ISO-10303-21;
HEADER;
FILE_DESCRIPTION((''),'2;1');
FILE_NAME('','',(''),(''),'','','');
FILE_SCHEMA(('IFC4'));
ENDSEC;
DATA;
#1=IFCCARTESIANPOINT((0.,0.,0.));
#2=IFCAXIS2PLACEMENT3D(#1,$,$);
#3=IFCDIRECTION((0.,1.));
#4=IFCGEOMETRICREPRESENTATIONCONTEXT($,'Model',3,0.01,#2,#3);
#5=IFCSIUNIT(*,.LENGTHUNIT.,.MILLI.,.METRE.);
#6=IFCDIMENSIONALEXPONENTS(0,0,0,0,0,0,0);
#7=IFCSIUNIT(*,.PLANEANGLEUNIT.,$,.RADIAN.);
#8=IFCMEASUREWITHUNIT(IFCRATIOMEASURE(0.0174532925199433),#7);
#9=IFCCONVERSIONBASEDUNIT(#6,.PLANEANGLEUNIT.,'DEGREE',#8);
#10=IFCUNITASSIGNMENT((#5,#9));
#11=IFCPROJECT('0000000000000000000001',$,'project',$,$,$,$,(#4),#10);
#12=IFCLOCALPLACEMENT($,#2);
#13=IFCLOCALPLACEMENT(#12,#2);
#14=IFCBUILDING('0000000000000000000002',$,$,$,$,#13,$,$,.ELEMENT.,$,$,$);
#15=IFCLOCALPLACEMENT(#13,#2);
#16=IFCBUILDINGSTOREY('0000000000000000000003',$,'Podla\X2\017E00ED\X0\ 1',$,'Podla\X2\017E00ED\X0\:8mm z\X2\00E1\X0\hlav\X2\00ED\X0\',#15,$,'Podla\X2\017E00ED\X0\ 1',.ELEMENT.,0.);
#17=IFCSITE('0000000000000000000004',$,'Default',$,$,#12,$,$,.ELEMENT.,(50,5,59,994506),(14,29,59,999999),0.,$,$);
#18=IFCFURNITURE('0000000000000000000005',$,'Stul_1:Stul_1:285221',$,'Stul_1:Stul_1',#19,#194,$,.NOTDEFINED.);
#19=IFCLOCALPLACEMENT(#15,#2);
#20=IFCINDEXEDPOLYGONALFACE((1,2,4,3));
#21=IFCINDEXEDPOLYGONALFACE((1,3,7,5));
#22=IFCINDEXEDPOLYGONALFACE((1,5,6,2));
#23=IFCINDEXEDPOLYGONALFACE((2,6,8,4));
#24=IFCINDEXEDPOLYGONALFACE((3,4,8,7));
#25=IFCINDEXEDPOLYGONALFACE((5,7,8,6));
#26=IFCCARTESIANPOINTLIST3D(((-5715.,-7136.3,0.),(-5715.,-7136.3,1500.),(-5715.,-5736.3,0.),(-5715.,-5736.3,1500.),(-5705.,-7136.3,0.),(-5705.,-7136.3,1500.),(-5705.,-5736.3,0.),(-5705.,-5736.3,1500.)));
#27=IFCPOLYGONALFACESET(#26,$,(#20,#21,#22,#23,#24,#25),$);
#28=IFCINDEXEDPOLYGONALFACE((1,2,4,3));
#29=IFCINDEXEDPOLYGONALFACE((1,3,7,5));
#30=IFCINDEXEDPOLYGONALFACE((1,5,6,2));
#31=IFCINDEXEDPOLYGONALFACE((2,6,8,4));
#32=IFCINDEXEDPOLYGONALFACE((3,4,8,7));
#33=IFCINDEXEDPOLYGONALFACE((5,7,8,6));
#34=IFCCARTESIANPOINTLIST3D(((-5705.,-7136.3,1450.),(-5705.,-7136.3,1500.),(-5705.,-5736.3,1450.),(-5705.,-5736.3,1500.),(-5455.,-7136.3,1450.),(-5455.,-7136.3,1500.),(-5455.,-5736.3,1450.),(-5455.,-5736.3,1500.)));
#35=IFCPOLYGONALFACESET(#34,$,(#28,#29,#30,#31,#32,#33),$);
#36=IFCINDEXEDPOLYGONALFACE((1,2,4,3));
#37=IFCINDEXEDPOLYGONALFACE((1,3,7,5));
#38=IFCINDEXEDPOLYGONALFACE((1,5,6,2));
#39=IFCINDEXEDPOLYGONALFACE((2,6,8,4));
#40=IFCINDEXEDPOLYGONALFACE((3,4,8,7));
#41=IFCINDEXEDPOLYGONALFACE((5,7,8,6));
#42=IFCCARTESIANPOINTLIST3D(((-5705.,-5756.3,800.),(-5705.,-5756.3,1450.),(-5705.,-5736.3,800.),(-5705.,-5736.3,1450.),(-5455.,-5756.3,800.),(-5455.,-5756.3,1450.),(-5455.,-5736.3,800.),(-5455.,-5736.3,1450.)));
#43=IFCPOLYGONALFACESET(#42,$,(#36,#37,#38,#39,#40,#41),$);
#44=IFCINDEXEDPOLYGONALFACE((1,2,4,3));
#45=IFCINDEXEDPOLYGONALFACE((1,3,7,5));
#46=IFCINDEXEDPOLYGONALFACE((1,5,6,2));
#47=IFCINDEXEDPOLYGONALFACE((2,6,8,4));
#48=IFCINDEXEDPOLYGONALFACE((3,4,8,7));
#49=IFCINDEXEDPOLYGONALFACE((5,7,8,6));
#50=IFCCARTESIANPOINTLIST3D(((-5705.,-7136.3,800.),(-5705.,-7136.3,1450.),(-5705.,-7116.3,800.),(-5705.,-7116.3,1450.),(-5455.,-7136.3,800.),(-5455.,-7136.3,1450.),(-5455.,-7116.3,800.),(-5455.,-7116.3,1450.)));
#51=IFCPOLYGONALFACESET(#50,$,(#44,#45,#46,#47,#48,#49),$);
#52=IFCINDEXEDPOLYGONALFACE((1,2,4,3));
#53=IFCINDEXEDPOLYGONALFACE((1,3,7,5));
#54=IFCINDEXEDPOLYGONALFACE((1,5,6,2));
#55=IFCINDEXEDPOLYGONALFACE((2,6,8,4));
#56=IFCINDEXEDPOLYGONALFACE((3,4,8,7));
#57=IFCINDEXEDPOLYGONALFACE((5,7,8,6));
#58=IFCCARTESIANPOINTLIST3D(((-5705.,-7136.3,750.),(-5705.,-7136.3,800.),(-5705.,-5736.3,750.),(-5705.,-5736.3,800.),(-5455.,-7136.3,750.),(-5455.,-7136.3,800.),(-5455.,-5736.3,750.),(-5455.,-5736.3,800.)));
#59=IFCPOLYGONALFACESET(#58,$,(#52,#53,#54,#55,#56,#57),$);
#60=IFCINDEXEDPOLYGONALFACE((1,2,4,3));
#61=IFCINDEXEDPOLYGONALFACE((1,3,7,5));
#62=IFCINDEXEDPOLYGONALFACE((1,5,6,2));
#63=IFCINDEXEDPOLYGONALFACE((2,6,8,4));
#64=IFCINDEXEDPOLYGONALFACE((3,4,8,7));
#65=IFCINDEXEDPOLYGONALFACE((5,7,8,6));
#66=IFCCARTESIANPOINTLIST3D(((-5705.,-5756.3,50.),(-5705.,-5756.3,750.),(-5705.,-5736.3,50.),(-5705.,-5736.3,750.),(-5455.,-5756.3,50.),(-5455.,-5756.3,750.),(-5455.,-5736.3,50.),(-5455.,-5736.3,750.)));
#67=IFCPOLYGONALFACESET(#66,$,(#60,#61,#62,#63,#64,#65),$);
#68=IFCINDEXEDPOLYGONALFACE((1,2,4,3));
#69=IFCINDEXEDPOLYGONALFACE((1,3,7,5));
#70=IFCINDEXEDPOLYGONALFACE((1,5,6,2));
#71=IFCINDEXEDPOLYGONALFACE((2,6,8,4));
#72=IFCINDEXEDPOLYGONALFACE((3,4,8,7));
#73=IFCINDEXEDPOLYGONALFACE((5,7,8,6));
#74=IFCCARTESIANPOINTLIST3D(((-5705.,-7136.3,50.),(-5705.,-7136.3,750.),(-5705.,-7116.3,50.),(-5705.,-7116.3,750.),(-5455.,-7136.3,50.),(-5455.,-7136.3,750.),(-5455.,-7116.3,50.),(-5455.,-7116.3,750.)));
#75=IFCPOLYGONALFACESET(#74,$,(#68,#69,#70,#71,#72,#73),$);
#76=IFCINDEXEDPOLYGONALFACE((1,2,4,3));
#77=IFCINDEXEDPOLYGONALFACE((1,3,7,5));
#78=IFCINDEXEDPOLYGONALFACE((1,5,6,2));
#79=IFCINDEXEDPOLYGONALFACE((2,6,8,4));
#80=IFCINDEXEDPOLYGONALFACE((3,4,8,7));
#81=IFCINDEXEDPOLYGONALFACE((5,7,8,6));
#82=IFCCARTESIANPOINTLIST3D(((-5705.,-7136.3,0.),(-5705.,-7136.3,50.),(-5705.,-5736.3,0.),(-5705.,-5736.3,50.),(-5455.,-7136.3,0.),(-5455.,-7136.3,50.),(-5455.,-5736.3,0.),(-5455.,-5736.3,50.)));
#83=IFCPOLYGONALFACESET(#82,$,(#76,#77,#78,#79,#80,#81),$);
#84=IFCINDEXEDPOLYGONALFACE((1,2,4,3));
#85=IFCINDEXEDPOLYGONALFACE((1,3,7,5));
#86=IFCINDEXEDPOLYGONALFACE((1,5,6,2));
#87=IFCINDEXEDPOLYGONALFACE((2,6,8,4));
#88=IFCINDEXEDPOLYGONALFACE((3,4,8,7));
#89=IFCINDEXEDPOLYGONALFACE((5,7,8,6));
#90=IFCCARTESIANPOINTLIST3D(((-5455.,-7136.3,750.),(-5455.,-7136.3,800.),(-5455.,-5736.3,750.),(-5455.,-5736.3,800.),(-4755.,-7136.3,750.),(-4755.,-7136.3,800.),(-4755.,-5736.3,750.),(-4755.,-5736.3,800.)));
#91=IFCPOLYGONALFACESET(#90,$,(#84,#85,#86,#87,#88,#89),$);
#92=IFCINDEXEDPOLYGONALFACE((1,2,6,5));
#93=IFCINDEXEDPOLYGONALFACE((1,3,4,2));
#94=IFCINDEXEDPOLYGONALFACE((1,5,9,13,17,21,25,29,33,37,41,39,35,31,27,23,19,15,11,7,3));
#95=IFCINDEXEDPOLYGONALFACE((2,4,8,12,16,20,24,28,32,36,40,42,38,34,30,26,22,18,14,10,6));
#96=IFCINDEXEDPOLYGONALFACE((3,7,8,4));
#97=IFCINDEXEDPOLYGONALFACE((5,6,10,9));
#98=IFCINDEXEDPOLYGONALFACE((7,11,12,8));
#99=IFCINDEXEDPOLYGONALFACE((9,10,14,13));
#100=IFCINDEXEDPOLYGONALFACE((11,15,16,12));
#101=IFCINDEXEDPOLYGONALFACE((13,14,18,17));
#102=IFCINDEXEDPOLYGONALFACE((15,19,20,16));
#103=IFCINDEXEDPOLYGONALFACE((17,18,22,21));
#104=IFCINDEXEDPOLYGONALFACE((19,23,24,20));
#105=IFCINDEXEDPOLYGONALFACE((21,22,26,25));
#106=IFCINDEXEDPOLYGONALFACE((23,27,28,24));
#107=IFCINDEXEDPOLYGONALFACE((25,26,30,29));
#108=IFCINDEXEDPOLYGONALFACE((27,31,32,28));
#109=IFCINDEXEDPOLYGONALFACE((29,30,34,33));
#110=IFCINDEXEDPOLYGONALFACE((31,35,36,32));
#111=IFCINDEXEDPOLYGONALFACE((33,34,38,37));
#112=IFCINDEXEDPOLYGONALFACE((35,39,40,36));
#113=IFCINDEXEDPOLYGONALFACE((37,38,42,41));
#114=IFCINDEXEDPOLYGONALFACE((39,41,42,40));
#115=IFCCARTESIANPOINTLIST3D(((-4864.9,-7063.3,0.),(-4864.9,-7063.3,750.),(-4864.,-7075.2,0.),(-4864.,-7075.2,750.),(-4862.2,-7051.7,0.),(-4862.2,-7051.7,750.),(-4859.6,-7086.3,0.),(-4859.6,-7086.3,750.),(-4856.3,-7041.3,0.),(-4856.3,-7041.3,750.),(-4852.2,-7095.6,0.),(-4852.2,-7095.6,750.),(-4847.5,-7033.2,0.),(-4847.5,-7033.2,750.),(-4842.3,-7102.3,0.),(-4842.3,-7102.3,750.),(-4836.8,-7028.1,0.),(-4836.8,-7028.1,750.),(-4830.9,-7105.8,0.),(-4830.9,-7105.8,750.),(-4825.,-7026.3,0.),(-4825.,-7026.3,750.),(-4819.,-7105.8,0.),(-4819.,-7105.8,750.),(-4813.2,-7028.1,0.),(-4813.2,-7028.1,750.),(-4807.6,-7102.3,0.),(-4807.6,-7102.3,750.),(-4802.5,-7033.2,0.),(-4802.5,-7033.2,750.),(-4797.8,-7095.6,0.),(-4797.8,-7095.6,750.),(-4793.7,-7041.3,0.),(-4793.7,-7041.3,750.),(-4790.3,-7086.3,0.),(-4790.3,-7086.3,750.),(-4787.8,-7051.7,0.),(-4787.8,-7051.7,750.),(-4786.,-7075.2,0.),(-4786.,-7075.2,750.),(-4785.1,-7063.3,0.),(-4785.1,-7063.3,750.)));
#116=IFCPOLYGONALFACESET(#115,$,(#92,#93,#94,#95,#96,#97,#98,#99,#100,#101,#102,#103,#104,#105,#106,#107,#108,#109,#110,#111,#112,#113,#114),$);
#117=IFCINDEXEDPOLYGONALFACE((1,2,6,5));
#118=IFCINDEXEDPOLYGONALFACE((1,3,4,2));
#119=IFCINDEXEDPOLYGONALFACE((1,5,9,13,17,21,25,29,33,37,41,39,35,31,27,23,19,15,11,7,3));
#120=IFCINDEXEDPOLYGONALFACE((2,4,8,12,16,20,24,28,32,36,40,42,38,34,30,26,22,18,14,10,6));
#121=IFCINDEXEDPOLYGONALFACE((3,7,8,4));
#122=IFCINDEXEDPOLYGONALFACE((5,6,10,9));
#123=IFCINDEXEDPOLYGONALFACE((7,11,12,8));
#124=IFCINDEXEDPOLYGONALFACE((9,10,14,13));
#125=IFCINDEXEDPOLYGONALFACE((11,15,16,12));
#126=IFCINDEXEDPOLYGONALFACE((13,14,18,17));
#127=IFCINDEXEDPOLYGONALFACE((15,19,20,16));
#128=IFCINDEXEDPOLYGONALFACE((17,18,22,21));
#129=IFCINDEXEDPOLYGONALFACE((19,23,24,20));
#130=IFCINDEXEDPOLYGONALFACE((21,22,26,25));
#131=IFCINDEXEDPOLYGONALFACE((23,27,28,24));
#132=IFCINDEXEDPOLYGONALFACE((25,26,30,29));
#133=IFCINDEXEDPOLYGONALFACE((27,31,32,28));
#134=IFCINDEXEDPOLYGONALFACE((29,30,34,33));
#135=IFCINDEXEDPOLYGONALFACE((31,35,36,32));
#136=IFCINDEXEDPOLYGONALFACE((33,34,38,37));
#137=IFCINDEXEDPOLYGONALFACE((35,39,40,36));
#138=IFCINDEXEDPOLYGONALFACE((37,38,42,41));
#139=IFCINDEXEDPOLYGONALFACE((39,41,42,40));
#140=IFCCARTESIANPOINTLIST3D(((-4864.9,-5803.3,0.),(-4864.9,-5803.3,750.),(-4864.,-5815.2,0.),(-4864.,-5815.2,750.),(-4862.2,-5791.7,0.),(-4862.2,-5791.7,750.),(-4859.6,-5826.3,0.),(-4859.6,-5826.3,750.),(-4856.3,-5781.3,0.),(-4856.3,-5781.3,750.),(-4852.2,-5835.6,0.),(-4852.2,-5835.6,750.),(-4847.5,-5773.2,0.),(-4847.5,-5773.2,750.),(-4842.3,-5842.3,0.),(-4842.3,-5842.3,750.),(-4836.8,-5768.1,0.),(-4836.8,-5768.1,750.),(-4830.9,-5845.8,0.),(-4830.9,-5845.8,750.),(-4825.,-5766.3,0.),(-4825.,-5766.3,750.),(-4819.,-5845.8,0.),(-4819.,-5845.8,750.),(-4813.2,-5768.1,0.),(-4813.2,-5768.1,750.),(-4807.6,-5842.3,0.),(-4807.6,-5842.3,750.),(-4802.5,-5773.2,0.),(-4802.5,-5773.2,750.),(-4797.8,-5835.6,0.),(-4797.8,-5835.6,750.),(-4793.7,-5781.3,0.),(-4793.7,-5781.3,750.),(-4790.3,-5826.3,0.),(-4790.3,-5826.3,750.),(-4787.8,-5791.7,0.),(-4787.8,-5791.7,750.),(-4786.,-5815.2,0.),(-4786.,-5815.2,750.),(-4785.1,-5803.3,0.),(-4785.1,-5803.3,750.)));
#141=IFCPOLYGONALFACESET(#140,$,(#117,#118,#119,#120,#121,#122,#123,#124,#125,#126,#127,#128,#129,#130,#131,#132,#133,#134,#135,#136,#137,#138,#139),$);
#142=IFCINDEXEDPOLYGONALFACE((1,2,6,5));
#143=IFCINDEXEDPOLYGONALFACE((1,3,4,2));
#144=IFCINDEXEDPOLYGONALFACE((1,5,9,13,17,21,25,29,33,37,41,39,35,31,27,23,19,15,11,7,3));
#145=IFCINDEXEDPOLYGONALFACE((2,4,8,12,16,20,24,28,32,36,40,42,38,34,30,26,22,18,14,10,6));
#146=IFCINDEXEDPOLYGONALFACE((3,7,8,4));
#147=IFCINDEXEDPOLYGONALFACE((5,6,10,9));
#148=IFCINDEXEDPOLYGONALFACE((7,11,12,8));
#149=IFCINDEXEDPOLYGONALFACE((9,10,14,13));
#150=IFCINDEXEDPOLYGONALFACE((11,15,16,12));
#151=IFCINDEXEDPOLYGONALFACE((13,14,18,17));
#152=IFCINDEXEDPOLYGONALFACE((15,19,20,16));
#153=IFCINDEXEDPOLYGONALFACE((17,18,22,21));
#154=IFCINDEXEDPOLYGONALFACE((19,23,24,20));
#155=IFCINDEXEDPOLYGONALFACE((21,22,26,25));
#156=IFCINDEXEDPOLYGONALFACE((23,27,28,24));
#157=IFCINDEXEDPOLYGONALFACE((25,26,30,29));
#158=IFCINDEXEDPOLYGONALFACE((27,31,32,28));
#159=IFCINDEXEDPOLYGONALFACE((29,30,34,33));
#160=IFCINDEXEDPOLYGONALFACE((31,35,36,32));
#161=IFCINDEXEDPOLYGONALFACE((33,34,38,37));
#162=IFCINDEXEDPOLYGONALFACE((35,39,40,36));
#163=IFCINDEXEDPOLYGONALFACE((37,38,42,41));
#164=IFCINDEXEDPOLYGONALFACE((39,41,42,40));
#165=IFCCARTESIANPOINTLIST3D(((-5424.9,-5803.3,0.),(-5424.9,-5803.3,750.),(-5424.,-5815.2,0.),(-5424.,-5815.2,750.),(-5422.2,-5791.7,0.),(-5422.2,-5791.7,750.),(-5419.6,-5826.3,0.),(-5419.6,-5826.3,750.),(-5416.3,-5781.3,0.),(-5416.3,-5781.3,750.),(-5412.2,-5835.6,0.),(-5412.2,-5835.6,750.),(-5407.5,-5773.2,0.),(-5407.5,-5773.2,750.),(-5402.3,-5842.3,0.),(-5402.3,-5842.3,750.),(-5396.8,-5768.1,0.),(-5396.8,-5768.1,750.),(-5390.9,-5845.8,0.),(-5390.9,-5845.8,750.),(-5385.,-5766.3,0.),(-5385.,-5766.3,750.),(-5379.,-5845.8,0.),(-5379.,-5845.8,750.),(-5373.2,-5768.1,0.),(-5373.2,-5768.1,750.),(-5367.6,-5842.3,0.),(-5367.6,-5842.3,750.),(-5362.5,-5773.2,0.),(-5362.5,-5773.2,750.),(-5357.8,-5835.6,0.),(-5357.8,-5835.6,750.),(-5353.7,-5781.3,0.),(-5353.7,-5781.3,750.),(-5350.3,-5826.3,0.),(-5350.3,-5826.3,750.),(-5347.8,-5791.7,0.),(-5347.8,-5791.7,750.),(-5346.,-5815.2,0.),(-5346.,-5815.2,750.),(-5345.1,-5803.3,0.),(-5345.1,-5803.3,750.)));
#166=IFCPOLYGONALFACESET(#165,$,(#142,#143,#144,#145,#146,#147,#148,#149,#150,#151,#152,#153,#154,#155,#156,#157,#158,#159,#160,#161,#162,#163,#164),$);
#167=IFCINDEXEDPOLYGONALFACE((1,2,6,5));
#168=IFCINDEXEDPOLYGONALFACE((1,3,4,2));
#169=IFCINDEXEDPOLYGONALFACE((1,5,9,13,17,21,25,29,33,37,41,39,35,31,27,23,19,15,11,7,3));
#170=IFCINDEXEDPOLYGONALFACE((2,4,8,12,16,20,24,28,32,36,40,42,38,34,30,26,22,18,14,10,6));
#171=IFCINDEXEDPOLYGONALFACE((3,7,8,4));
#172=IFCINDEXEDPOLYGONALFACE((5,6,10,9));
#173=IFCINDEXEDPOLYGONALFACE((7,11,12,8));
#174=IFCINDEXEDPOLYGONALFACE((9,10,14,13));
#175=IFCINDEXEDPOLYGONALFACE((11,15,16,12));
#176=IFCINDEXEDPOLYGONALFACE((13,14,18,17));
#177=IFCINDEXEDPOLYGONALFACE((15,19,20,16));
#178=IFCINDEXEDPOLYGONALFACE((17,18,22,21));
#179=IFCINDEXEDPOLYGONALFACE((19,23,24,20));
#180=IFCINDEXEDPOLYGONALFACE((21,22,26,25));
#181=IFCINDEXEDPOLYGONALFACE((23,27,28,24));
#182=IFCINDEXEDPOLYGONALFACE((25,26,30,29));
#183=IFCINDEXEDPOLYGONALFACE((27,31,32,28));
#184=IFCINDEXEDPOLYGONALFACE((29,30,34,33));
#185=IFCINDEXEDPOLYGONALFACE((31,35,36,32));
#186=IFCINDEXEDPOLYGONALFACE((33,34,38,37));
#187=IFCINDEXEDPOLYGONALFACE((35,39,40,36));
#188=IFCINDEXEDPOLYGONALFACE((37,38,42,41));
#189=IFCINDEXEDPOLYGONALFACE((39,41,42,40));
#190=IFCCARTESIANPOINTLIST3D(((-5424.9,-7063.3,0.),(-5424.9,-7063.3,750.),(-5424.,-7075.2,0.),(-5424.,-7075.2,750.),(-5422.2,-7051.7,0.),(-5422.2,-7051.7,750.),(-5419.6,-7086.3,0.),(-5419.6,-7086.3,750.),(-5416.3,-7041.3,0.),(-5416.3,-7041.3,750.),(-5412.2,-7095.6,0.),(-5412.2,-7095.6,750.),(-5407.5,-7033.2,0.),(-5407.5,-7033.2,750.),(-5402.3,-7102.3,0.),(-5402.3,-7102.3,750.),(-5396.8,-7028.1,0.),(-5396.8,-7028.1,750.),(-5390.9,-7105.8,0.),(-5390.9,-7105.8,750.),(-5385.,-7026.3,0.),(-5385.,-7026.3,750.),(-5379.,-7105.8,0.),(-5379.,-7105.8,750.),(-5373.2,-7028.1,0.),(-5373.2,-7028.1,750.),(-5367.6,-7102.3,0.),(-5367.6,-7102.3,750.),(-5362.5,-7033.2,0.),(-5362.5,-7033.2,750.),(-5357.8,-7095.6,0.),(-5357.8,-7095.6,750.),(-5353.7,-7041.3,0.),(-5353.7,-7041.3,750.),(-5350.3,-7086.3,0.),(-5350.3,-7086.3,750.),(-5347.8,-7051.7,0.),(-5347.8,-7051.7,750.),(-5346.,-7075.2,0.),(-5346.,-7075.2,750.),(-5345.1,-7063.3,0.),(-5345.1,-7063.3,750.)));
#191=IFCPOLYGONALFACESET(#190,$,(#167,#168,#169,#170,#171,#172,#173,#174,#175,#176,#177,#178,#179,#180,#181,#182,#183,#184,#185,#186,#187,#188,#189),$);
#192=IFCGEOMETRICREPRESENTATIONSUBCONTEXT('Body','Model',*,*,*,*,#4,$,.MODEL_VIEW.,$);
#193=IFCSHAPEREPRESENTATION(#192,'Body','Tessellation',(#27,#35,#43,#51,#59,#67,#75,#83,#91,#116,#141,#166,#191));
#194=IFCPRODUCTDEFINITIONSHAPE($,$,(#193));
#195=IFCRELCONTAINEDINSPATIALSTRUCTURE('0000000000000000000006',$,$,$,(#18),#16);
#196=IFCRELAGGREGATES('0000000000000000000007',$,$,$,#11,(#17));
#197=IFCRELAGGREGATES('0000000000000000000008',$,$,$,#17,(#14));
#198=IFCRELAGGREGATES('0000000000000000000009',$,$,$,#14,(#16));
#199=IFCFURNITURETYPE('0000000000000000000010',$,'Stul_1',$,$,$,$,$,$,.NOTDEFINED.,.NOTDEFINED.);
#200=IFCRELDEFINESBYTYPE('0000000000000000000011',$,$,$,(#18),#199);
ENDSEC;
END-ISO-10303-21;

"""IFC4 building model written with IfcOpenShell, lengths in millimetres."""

from ifc_helpers import new_model, entity, si_unit, converted_unit, direction, frame, frame_2d, origin, origin_2d_with_axis, place, context, subcontext, project, spatial, rectangle, circle, extrude, source, transform, mapped, type_object, type_shapes, element, save


model = new_model("IFC4")

# Units and contexts
model_context = context("Model", 3, precision=0.01, world=origin(), true_north=direction((0.0, 1.0)))
body_context = subcontext(model_context, "Body", "Model", "MODEL_VIEW")
ifc_project = project(units=[si_unit("LENGTHUNIT", "METRE", prefix="MILLI"), converted_unit("PLANEANGLEUNIT", "DEGREE", entity("IfcRatioMeasure", 0.0174532925199433), si_unit("PLANEANGLEUNIT", "RADIAN"), dimensions=[0, 0, 0, 0, 0, 0, 0])], contexts=[model_context])

# Site, building, storey
site_placement = place(None, origin())
site = spatial("IfcSite", under=ifc_project, at=site_placement, Name="Default", CompositionType="ELEMENT", RefLatitude=(50, 5, 59, 994506), RefLongitude=(14, 29, 59, 999999), RefElevation=0.0)
building_placement = place(site_placement, origin())
building = spatial("IfcBuilding", under=site, at=building_placement, CompositionType="ELEMENT")
storey_placement = place(building_placement, origin())
storey = spatial("IfcBuildingStorey", under=building, at=storey_placement, Name="Podlaží 1", ObjectType="Podlaží:8mm záhlaví", LongName="Podlaží 1", CompositionType="ELEMENT", Elevation=0.0)

# Furniture
furniture_type = type_object("IfcFurnitureType", Name="Stul_1", AssemblyPlace="NOTDEFINED", PredefinedType="NOTDEFINED")
shared_shape_1 = source(origin(), body_context, "Body", "SweptSolid", [
    extrude(rectangle(XDim=1400.0, YDim=10.0, at=origin_2d_with_axis()), frame((0.0, 605.0, 0.0), z_axis=(0.0, 0.0, 1.0), x_axis=(-1.0, 0.0, 0.0)), (0.0, 0.0, 1.0), 1500.0),
    extrude(rectangle(XDim=1400.0, YDim=250.0, at=frame_2d((0.0, 0.0), x_axis=(1.0, 0.0))), frame((0.0, 475.0, 1450.0), z_axis=(0.0, 0.0, 1.0), x_axis=(-1.0, 0.0, 0.0)), (0.0, 0.0, 1.0), 50.0),
    extrude(rectangle(XDim=20.0, YDim=250.0, at=origin_2d_with_axis()), frame((690.0, 475.0, 800.0), z_axis=(0.0, 0.0, 1.0), x_axis=(-1.0, 0.0, 0.0)), (0.0, 0.0, 1.0), 650.0),
    extrude(rectangle(XDim=20.0, YDim=250.0, at=frame_2d((0.0, 0.0), x_axis=(1.0, 0.0))), frame((-690.0, 475.0, 800.0), z_axis=(0.0, 0.0, 1.0), x_axis=(-1.0, 0.0, 0.0)), (0.0, 0.0, 1.0), 650.0),
    extrude(rectangle(XDim=1400.0, YDim=250.0, at=origin_2d_with_axis()), frame((0.0, 475.0, 750.0), z_axis=(0.0, 0.0, 1.0), x_axis=(-1.0, 0.0, 0.0)), (0.0, 0.0, 1.0), 50.0),
    extrude(rectangle(XDim=20.0, YDim=250.0, at=origin_2d_with_axis()), frame((690.0, 475.0, 50.0), z_axis=(0.0, 0.0, 1.0), x_axis=(-1.0, 0.0, 0.0)), (0.0, 0.0, 1.0), 700.0),
    extrude(rectangle(XDim=20.0, YDim=250.0, at=frame_2d((0.0, 0.0), x_axis=(1.0, 0.0))), frame((-690.0, 475.0, 50.0), z_axis=(0.0, 0.0, 1.0), x_axis=(-1.0, 0.0, 0.0)), (0.0, 0.0, 1.0), 700.0),
    extrude(rectangle(XDim=1400.0, YDim=250.0, at=origin_2d_with_axis()), frame((0.0, 475.0, 0.0), z_axis=(0.0, 0.0, 1.0), x_axis=(-1.0, 0.0, 0.0)), (0.0, 0.0, 1.0), 50.0),
    extrude(rectangle(XDim=1400.0, YDim=700.0, at=origin_2d_with_axis()), frame((0.0, 0.0, 750.0), z_axis=(0.0, 0.0, 1.0), x_axis=(-1.0, 0.0, 0.0)), (0.0, 0.0, 1.0), 50.0),
    extrude(circle(Radius=40.0, at=frame_2d((0.0, 0.0), x_axis=(1.0, 0.0))), frame((-630.0, -280.0, 0.0)), (0.0, 0.0, 1.0), 750.0),
    extrude(circle(Radius=40.0, at=frame_2d((0.0, 0.0), x_axis=(1.0, 0.0))), frame((630.0, -280.0, 0.0)), (0.0, 0.0, 1.0), 750.0),
    extrude(circle(Radius=40.0, at=frame_2d((0.0, 0.0), x_axis=(1.0, 0.0))), frame((630.0, 280.0, 0.0)), (0.0, 0.0, 1.0), 750.0),
    extrude(circle(Radius=40.0, at=frame_2d((0.0, 0.0), x_axis=(1.0, 0.0))), frame((-630.0, 280.0, 0.0)), (0.0, 0.0, 1.0), 750.0),
])
type_shapes(furniture_type, [shared_shape_1])
for number, where, z_axis, x_axis, name in (
    (1, (-5105.0, -6436.3, 0.0), (0.0, 0.0, 1.0), (0.0, 1.0, 0.0), "Stul_1:Stul_1:285221"),
):
    element("IfcFurniture", number, at=place(storey_placement, frame(where, z_axis=z_axis, x_axis=x_axis)), inside=storey, type_object=furniture_type, Name=name, ObjectType="Stul_1:Stul_1", PredefinedType="NOTDEFINED", context=body_context, shape_type="MappedRepresentation", body=[
        mapped(shared_shape_1, transform((0.0, 0.0, 0.0), scale=1.0)),
    ])

save(model, "model.ifc")
